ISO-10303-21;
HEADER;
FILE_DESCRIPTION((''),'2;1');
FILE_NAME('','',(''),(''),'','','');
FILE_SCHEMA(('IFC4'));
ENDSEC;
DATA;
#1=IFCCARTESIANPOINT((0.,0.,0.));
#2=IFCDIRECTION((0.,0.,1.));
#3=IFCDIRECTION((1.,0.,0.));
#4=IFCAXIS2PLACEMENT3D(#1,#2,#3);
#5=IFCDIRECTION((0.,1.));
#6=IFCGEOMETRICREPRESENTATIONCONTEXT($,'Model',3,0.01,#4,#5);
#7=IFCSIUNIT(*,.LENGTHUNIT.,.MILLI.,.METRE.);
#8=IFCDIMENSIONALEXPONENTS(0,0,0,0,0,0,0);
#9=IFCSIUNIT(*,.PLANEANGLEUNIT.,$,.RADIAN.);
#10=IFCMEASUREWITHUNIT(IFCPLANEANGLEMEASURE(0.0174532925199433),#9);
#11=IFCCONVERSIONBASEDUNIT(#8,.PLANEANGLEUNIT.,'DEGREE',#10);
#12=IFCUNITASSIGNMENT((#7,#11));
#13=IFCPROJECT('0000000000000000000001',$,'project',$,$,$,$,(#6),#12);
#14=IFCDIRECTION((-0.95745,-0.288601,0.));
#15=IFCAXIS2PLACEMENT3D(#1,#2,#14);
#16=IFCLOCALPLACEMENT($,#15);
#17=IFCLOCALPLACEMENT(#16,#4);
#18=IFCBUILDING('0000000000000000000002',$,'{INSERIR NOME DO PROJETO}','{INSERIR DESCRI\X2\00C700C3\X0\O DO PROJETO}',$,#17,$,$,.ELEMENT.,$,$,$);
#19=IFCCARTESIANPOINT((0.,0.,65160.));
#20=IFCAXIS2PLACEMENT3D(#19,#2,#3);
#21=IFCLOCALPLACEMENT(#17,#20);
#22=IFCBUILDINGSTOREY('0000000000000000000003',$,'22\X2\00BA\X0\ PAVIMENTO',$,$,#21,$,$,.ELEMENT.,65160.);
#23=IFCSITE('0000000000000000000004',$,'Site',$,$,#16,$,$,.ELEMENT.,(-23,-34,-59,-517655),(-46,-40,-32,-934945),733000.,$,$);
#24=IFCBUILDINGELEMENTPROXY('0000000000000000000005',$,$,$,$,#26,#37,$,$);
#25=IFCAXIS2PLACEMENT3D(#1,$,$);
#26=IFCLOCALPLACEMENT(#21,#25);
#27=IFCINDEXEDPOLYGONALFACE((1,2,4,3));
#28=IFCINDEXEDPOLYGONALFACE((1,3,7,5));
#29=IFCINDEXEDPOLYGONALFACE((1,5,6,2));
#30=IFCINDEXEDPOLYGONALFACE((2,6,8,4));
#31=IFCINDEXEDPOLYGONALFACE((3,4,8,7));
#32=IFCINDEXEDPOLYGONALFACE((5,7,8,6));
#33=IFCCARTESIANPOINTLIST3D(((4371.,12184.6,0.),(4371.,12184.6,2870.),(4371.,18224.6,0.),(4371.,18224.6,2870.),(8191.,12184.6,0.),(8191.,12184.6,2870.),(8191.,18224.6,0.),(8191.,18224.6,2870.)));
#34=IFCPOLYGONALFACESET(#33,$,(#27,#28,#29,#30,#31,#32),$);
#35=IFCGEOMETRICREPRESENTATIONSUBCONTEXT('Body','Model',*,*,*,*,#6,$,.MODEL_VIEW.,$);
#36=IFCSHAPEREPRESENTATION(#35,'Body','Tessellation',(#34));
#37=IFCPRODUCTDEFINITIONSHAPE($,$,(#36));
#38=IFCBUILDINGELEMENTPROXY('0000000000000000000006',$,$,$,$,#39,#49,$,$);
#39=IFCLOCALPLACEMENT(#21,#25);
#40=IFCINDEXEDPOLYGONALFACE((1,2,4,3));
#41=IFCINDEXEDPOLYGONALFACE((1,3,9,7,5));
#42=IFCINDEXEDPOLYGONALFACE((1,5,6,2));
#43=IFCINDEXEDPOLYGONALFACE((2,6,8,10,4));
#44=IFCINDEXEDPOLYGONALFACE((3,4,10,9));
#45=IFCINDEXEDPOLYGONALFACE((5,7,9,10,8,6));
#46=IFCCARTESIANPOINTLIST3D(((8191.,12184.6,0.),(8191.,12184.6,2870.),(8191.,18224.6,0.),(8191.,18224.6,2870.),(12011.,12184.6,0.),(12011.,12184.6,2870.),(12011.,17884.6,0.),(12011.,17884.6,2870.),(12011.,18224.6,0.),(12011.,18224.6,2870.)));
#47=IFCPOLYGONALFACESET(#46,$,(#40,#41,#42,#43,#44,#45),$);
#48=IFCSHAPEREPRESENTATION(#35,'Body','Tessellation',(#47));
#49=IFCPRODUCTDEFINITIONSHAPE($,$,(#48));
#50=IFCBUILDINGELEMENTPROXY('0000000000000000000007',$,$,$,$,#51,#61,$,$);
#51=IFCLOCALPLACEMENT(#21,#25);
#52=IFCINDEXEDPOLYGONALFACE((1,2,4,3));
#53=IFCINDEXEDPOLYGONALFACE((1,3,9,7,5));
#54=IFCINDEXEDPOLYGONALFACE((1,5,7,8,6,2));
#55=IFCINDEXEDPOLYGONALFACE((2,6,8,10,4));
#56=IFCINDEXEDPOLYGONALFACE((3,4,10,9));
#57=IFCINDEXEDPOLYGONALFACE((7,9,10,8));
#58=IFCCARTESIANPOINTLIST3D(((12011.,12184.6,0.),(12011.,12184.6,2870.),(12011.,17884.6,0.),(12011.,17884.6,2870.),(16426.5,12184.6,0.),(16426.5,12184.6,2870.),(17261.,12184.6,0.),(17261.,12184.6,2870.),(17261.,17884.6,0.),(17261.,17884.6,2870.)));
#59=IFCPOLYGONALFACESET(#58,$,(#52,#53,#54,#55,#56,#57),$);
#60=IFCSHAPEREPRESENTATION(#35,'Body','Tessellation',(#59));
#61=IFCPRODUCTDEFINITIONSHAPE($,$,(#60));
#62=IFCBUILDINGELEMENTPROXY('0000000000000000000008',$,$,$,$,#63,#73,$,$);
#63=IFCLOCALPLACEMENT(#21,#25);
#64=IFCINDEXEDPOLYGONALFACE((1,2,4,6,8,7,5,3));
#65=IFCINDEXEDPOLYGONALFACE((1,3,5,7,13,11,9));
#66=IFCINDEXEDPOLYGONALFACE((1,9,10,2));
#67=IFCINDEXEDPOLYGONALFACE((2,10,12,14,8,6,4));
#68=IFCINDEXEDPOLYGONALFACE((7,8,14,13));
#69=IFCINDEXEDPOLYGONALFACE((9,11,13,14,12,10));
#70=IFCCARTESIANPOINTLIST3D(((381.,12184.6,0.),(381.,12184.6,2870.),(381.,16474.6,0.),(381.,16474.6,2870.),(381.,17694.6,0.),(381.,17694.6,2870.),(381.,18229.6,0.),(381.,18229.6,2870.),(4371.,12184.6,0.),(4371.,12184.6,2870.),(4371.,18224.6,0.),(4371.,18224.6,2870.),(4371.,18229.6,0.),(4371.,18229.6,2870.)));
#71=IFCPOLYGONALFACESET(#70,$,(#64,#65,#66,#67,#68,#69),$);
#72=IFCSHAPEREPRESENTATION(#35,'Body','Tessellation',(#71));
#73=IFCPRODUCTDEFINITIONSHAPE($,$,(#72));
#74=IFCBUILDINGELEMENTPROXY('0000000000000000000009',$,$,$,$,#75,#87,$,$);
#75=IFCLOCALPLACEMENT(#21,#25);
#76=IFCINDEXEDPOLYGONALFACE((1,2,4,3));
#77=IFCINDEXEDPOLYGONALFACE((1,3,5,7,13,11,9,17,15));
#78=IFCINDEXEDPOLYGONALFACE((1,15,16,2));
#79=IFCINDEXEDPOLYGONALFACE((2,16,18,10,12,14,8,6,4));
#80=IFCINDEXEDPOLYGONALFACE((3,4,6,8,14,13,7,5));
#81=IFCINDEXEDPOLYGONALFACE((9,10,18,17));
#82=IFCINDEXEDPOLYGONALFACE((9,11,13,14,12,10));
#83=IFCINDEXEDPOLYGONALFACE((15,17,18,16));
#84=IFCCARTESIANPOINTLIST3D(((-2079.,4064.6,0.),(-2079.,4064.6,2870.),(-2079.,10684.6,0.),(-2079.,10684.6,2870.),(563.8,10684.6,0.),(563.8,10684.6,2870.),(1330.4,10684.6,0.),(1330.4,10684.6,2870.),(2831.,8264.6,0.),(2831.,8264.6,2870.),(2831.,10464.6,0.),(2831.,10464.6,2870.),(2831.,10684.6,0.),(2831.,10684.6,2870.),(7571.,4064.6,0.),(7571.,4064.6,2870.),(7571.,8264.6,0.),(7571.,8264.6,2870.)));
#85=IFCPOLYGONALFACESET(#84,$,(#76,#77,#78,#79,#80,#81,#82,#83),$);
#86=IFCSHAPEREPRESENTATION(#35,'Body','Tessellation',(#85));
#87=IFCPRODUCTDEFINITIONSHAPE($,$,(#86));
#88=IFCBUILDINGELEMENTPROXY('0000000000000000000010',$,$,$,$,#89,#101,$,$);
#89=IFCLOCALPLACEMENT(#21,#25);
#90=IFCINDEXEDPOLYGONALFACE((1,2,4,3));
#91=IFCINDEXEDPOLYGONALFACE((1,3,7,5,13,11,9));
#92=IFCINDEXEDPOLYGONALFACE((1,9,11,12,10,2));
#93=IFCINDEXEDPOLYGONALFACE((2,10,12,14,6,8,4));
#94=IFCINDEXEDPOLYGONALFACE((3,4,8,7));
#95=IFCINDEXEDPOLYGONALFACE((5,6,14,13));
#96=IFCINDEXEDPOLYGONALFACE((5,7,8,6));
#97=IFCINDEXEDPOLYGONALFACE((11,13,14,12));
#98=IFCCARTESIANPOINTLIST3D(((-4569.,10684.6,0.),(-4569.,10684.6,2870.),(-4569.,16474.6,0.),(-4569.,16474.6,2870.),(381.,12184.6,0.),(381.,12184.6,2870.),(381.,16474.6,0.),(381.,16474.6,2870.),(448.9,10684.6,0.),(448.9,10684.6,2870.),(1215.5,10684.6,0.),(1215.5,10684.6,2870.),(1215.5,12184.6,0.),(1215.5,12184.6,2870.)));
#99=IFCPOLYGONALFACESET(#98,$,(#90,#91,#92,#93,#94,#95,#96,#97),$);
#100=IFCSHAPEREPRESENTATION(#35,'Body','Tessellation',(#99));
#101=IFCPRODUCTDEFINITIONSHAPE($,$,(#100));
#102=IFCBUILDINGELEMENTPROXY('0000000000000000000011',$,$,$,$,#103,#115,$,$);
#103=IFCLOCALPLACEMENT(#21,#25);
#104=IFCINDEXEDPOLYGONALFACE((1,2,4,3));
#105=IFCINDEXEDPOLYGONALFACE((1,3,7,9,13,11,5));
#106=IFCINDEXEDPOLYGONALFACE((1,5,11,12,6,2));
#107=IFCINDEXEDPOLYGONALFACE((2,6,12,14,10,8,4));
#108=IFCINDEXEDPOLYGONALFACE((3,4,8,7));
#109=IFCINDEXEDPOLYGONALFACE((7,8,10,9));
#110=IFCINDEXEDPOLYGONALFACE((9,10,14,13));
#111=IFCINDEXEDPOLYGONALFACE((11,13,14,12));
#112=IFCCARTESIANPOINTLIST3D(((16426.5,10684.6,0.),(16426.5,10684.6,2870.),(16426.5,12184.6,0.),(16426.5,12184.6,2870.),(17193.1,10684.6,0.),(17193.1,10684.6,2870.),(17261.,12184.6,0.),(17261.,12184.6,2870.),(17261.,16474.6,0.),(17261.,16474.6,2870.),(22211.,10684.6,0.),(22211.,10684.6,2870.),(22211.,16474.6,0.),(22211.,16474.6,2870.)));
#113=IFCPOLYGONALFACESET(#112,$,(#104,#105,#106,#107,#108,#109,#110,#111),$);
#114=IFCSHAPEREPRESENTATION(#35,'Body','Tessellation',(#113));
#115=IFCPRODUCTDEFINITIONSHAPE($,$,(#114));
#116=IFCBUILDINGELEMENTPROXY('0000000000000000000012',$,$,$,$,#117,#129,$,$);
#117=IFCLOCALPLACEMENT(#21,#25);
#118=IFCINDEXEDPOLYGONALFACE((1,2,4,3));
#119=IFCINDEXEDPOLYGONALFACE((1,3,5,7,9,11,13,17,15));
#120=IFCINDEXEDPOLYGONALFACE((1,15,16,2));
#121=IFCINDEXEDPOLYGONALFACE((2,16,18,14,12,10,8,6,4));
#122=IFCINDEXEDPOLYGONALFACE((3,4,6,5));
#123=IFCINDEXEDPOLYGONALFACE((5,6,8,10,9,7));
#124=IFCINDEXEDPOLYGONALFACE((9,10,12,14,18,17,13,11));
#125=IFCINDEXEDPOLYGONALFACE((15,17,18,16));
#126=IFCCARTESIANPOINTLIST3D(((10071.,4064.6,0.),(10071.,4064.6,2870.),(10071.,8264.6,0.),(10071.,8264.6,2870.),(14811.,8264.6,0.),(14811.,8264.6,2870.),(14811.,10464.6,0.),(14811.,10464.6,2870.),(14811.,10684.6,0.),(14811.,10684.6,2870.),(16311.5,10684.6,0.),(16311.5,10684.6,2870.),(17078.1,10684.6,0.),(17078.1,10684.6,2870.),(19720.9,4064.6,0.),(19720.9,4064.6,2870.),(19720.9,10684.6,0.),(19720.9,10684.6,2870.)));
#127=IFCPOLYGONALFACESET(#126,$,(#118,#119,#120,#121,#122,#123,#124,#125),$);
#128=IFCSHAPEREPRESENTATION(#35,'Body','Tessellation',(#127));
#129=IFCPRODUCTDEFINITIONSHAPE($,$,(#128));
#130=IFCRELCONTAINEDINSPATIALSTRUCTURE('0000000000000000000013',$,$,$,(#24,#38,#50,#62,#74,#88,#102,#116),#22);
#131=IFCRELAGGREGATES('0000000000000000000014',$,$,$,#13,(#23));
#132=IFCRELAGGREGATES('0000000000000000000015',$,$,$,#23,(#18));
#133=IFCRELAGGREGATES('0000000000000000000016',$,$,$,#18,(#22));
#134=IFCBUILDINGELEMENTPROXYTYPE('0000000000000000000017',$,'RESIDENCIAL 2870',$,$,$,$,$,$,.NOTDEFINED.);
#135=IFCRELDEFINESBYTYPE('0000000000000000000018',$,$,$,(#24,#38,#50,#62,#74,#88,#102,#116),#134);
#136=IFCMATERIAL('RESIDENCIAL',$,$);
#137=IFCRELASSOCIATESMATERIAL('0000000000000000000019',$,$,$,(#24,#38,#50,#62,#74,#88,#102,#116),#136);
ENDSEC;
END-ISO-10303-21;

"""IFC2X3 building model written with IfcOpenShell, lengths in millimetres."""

from ifc_helpers import new_model, entity, si_unit, converted_unit, direction, frame, origin_with_axes, place, context, subcontext, project, spatial, polyline, outline, extrude, material, type_object, element, save


model = new_model("IFC2X3")

# Units and contexts
model_context = context("Model", 3, precision=0.01, world=origin_with_axes(), true_north=direction((0.0, 1.0)))
body_context = subcontext(model_context, "Body", "Model", "MODEL_VIEW")
ifc_project = project(units=[si_unit("LENGTHUNIT", "METRE", prefix="MILLI"), converted_unit("PLANEANGLEUNIT", "DEGREE", entity("IfcPlaneAngleMeasure", 0.0174532925199433), si_unit("PLANEANGLEUNIT", "RADIAN"), dimensions=[0, 0, 0, 0, 0, 0, 0])], contexts=[model_context])

# Site, building, storey
site_placement = place(None, frame((0.0, 0.0, 0.0), z_axis=(0.0, 0.0, 1.0), x_axis=(-0.95745, -0.288601, 0.0)))
site = spatial("IfcSite", under=ifc_project, at=site_placement, Name="Site", CompositionType="ELEMENT", RefLatitude=(-23, -34, -59, -517655), RefLongitude=(-46, -40, -32, -934945), RefElevation=733000.0)
building_placement = place(site_placement, origin_with_axes())
building = spatial("IfcBuilding", under=site, at=building_placement, Name="{INSERIR NOME DO PROJETO}", Description="{INSERIR DESCRIÇÃO DO PROJETO}", CompositionType="ELEMENT")
storey_placement = place(building_placement, frame((0.0, 0.0, 65160.0), z_axis=(0.0, 0.0, 1.0), x_axis=(1.0, 0.0, 0.0)))
storey = spatial("IfcBuildingStorey", under=building, at=storey_placement, Name="22º PAVIMENTO", CompositionType="ELEMENT", Elevation=65160.0)

# Building element proxies
ifc_material_1 = material(Name="RESIDENCIAL")
building_element_proxy_type_1 = type_object("IfcBuildingElementProxyType", Name="RESIDENCIAL 2870", PredefinedType="NOTDEFINED")
proxy_1_placement = place(storey_placement, frame((4371.0, 18224.6, 0.0), z_axis=(0.0, 0.0, 1.0), x_axis=(1.0, 0.0, 0.0)))
element("IfcBuildingElementProxy", 1, at=proxy_1_placement, inside=storey, type_object=building_element_proxy_type_1, material=ifc_material_1, context=body_context, shape_type="SweptSolid", body=[
    extrude(outline(polyline([(0.0, 0.0), (0.0, -6040.0), (3820.0, -6040.0), (3820.0, 0.0), (0.0, 0.0)])), origin_with_axes(), (0.0, 0.0, 1.0), 2870.0),
])
proxy_2_placement = place(storey_placement, frame((8191.0, 18224.6, 0.0), z_axis=(0.0, 0.0, 1.0), x_axis=(1.0, 0.0, 0.0)))
element("IfcBuildingElementProxy", 2, at=proxy_2_placement, inside=storey, type_object=building_element_proxy_type_1, material=ifc_material_1, context=body_context, shape_type="SweptSolid", body=[
    extrude(outline(polyline([(0.0, 0.0), (0.0, -6040.0), (3820.0, -6040.0), (3820.0, -340.0), (3820.0, 0.0), (0.0, 0.0)])), origin_with_axes(), (0.0, 0.0, 1.0), 2870.0),
])
proxy_3_placement = place(storey_placement, frame((12011.0, 12184.6, 0.0), z_axis=(0.0, 0.0, 1.0), x_axis=(1.0, 0.0, 0.0)))
element("IfcBuildingElementProxy", 3, at=proxy_3_placement, inside=storey, type_object=building_element_proxy_type_1, material=ifc_material_1, context=body_context, shape_type="SweptSolid", body=[
    extrude(outline(polyline([(0.0, 0.0), (4415.5, 0.0), (5250.0, 0.0), (5250.0, 5700.0), (0.0, 5700.0), (0.0, 0.0)])), origin_with_axes(), (0.0, 0.0, 1.0), 2870.0),
])
proxy_4_placement = place(storey_placement, frame((381.0, 16474.6, 0.0), z_axis=(0.0, 0.0, 1.0), x_axis=(1.0, 0.0, 0.0)))
element("IfcBuildingElementProxy", 4, at=proxy_4_placement, inside=storey, type_object=building_element_proxy_type_1, material=ifc_material_1, context=body_context, shape_type="SweptSolid", body=[
    extrude(outline(polyline([(0.0, 0.0), (0.0, -4290.0), (3990.0, -4290.0), (3990.0, 1750.0), (3990.0, 1755.0), (0.0, 1755.0), (0.0, 1220.0), (0.0, 0.0)])), origin_with_axes(), (0.0, 0.0, 1.0), 2870.0),
])
proxy_5_placement = place(storey_placement, frame((-2079.0, 4064.6, 0.0), z_axis=(0.0, 0.0, 1.0), x_axis=(1.0, 0.0, 0.0)))
element("IfcBuildingElementProxy", 5, at=proxy_5_placement, inside=storey, type_object=building_element_proxy_type_1, material=ifc_material_1, context=body_context, shape_type="SweptSolid", body=[
    extrude(outline(polyline([(0.0, 0.0), (9650.0, 0.0), (9650.0, 4200.0), (4910.0, 4200.0), (4910.0, 6400.0), (4910.0, 6620.0), (3409.4, 6620.0), (2642.8, 6620.0), (0.0, 6620.0), (0.0, 0.0)])), origin_with_axes(), (0.0, 0.0, 1.0), 2870.0),
])
proxy_6_placement = place(storey_placement, frame((-4569.0, 16474.6, 0.0), z_axis=(0.0, 0.0, 1.0), x_axis=(1.0, 0.0, 0.0)))
element("IfcBuildingElementProxy", 6, at=proxy_6_placement, inside=storey, type_object=building_element_proxy_type_1, material=ifc_material_1, context=body_context, shape_type="SweptSolid", body=[
    extrude(outline(polyline([(0.0, 0.0), (0.0, -5790.0), (5017.9, -5790.0), (5784.5, -5790.0), (5784.5, -4290.0), (4950.0, -4290.0), (4950.0, 0.0), (0.0, 0.0)])), origin_with_axes(), (0.0, 0.0, 1.0), 2870.0),
])
proxy_7_placement = place(storey_placement, frame((17261.0, 12184.6, 0.0), z_axis=(0.0, 0.0, 1.0), x_axis=(1.0, 0.0, 0.0)))
element("IfcBuildingElementProxy", 7, at=proxy_7_placement, inside=storey, type_object=building_element_proxy_type_1, material=ifc_material_1, context=body_context, shape_type="SweptSolid", body=[
    extrude(outline(polyline([(0.0, 0.0), (-834.5, 0.0), (-834.5, -1500.0), (-67.9, -1500.0), (4950.0, -1500.0), (4950.0, 4290.0), (0.0, 4290.0), (0.0, 0.0)])), origin_with_axes(), (0.0, 0.0, 1.0), 2870.0),
])
proxy_8_placement = place(storey_placement, frame((19720.9, 4064.6, 0.0), z_axis=(0.0, 0.0, 1.0), x_axis=(1.0, 0.0, 0.0)))
element("IfcBuildingElementProxy", 8, at=proxy_8_placement, inside=storey, type_object=building_element_proxy_type_1, material=ifc_material_1, context=body_context, shape_type="SweptSolid", body=[
    extrude(outline(polyline([(0.0, 0.0), (0.0, 6620.0), (-2642.8, 6620.0), (-3409.4, 6620.0), (-4910.0, 6620.0), (-4910.0, 6400.0), (-4910.0, 4200.0), (-9650.0, 4200.0), (-9650.0, 0.0), (0.0, 0.0)])), origin_with_axes(), (0.0, 0.0, 1.0), 2870.0),
])

save(model, "model.ifc")
